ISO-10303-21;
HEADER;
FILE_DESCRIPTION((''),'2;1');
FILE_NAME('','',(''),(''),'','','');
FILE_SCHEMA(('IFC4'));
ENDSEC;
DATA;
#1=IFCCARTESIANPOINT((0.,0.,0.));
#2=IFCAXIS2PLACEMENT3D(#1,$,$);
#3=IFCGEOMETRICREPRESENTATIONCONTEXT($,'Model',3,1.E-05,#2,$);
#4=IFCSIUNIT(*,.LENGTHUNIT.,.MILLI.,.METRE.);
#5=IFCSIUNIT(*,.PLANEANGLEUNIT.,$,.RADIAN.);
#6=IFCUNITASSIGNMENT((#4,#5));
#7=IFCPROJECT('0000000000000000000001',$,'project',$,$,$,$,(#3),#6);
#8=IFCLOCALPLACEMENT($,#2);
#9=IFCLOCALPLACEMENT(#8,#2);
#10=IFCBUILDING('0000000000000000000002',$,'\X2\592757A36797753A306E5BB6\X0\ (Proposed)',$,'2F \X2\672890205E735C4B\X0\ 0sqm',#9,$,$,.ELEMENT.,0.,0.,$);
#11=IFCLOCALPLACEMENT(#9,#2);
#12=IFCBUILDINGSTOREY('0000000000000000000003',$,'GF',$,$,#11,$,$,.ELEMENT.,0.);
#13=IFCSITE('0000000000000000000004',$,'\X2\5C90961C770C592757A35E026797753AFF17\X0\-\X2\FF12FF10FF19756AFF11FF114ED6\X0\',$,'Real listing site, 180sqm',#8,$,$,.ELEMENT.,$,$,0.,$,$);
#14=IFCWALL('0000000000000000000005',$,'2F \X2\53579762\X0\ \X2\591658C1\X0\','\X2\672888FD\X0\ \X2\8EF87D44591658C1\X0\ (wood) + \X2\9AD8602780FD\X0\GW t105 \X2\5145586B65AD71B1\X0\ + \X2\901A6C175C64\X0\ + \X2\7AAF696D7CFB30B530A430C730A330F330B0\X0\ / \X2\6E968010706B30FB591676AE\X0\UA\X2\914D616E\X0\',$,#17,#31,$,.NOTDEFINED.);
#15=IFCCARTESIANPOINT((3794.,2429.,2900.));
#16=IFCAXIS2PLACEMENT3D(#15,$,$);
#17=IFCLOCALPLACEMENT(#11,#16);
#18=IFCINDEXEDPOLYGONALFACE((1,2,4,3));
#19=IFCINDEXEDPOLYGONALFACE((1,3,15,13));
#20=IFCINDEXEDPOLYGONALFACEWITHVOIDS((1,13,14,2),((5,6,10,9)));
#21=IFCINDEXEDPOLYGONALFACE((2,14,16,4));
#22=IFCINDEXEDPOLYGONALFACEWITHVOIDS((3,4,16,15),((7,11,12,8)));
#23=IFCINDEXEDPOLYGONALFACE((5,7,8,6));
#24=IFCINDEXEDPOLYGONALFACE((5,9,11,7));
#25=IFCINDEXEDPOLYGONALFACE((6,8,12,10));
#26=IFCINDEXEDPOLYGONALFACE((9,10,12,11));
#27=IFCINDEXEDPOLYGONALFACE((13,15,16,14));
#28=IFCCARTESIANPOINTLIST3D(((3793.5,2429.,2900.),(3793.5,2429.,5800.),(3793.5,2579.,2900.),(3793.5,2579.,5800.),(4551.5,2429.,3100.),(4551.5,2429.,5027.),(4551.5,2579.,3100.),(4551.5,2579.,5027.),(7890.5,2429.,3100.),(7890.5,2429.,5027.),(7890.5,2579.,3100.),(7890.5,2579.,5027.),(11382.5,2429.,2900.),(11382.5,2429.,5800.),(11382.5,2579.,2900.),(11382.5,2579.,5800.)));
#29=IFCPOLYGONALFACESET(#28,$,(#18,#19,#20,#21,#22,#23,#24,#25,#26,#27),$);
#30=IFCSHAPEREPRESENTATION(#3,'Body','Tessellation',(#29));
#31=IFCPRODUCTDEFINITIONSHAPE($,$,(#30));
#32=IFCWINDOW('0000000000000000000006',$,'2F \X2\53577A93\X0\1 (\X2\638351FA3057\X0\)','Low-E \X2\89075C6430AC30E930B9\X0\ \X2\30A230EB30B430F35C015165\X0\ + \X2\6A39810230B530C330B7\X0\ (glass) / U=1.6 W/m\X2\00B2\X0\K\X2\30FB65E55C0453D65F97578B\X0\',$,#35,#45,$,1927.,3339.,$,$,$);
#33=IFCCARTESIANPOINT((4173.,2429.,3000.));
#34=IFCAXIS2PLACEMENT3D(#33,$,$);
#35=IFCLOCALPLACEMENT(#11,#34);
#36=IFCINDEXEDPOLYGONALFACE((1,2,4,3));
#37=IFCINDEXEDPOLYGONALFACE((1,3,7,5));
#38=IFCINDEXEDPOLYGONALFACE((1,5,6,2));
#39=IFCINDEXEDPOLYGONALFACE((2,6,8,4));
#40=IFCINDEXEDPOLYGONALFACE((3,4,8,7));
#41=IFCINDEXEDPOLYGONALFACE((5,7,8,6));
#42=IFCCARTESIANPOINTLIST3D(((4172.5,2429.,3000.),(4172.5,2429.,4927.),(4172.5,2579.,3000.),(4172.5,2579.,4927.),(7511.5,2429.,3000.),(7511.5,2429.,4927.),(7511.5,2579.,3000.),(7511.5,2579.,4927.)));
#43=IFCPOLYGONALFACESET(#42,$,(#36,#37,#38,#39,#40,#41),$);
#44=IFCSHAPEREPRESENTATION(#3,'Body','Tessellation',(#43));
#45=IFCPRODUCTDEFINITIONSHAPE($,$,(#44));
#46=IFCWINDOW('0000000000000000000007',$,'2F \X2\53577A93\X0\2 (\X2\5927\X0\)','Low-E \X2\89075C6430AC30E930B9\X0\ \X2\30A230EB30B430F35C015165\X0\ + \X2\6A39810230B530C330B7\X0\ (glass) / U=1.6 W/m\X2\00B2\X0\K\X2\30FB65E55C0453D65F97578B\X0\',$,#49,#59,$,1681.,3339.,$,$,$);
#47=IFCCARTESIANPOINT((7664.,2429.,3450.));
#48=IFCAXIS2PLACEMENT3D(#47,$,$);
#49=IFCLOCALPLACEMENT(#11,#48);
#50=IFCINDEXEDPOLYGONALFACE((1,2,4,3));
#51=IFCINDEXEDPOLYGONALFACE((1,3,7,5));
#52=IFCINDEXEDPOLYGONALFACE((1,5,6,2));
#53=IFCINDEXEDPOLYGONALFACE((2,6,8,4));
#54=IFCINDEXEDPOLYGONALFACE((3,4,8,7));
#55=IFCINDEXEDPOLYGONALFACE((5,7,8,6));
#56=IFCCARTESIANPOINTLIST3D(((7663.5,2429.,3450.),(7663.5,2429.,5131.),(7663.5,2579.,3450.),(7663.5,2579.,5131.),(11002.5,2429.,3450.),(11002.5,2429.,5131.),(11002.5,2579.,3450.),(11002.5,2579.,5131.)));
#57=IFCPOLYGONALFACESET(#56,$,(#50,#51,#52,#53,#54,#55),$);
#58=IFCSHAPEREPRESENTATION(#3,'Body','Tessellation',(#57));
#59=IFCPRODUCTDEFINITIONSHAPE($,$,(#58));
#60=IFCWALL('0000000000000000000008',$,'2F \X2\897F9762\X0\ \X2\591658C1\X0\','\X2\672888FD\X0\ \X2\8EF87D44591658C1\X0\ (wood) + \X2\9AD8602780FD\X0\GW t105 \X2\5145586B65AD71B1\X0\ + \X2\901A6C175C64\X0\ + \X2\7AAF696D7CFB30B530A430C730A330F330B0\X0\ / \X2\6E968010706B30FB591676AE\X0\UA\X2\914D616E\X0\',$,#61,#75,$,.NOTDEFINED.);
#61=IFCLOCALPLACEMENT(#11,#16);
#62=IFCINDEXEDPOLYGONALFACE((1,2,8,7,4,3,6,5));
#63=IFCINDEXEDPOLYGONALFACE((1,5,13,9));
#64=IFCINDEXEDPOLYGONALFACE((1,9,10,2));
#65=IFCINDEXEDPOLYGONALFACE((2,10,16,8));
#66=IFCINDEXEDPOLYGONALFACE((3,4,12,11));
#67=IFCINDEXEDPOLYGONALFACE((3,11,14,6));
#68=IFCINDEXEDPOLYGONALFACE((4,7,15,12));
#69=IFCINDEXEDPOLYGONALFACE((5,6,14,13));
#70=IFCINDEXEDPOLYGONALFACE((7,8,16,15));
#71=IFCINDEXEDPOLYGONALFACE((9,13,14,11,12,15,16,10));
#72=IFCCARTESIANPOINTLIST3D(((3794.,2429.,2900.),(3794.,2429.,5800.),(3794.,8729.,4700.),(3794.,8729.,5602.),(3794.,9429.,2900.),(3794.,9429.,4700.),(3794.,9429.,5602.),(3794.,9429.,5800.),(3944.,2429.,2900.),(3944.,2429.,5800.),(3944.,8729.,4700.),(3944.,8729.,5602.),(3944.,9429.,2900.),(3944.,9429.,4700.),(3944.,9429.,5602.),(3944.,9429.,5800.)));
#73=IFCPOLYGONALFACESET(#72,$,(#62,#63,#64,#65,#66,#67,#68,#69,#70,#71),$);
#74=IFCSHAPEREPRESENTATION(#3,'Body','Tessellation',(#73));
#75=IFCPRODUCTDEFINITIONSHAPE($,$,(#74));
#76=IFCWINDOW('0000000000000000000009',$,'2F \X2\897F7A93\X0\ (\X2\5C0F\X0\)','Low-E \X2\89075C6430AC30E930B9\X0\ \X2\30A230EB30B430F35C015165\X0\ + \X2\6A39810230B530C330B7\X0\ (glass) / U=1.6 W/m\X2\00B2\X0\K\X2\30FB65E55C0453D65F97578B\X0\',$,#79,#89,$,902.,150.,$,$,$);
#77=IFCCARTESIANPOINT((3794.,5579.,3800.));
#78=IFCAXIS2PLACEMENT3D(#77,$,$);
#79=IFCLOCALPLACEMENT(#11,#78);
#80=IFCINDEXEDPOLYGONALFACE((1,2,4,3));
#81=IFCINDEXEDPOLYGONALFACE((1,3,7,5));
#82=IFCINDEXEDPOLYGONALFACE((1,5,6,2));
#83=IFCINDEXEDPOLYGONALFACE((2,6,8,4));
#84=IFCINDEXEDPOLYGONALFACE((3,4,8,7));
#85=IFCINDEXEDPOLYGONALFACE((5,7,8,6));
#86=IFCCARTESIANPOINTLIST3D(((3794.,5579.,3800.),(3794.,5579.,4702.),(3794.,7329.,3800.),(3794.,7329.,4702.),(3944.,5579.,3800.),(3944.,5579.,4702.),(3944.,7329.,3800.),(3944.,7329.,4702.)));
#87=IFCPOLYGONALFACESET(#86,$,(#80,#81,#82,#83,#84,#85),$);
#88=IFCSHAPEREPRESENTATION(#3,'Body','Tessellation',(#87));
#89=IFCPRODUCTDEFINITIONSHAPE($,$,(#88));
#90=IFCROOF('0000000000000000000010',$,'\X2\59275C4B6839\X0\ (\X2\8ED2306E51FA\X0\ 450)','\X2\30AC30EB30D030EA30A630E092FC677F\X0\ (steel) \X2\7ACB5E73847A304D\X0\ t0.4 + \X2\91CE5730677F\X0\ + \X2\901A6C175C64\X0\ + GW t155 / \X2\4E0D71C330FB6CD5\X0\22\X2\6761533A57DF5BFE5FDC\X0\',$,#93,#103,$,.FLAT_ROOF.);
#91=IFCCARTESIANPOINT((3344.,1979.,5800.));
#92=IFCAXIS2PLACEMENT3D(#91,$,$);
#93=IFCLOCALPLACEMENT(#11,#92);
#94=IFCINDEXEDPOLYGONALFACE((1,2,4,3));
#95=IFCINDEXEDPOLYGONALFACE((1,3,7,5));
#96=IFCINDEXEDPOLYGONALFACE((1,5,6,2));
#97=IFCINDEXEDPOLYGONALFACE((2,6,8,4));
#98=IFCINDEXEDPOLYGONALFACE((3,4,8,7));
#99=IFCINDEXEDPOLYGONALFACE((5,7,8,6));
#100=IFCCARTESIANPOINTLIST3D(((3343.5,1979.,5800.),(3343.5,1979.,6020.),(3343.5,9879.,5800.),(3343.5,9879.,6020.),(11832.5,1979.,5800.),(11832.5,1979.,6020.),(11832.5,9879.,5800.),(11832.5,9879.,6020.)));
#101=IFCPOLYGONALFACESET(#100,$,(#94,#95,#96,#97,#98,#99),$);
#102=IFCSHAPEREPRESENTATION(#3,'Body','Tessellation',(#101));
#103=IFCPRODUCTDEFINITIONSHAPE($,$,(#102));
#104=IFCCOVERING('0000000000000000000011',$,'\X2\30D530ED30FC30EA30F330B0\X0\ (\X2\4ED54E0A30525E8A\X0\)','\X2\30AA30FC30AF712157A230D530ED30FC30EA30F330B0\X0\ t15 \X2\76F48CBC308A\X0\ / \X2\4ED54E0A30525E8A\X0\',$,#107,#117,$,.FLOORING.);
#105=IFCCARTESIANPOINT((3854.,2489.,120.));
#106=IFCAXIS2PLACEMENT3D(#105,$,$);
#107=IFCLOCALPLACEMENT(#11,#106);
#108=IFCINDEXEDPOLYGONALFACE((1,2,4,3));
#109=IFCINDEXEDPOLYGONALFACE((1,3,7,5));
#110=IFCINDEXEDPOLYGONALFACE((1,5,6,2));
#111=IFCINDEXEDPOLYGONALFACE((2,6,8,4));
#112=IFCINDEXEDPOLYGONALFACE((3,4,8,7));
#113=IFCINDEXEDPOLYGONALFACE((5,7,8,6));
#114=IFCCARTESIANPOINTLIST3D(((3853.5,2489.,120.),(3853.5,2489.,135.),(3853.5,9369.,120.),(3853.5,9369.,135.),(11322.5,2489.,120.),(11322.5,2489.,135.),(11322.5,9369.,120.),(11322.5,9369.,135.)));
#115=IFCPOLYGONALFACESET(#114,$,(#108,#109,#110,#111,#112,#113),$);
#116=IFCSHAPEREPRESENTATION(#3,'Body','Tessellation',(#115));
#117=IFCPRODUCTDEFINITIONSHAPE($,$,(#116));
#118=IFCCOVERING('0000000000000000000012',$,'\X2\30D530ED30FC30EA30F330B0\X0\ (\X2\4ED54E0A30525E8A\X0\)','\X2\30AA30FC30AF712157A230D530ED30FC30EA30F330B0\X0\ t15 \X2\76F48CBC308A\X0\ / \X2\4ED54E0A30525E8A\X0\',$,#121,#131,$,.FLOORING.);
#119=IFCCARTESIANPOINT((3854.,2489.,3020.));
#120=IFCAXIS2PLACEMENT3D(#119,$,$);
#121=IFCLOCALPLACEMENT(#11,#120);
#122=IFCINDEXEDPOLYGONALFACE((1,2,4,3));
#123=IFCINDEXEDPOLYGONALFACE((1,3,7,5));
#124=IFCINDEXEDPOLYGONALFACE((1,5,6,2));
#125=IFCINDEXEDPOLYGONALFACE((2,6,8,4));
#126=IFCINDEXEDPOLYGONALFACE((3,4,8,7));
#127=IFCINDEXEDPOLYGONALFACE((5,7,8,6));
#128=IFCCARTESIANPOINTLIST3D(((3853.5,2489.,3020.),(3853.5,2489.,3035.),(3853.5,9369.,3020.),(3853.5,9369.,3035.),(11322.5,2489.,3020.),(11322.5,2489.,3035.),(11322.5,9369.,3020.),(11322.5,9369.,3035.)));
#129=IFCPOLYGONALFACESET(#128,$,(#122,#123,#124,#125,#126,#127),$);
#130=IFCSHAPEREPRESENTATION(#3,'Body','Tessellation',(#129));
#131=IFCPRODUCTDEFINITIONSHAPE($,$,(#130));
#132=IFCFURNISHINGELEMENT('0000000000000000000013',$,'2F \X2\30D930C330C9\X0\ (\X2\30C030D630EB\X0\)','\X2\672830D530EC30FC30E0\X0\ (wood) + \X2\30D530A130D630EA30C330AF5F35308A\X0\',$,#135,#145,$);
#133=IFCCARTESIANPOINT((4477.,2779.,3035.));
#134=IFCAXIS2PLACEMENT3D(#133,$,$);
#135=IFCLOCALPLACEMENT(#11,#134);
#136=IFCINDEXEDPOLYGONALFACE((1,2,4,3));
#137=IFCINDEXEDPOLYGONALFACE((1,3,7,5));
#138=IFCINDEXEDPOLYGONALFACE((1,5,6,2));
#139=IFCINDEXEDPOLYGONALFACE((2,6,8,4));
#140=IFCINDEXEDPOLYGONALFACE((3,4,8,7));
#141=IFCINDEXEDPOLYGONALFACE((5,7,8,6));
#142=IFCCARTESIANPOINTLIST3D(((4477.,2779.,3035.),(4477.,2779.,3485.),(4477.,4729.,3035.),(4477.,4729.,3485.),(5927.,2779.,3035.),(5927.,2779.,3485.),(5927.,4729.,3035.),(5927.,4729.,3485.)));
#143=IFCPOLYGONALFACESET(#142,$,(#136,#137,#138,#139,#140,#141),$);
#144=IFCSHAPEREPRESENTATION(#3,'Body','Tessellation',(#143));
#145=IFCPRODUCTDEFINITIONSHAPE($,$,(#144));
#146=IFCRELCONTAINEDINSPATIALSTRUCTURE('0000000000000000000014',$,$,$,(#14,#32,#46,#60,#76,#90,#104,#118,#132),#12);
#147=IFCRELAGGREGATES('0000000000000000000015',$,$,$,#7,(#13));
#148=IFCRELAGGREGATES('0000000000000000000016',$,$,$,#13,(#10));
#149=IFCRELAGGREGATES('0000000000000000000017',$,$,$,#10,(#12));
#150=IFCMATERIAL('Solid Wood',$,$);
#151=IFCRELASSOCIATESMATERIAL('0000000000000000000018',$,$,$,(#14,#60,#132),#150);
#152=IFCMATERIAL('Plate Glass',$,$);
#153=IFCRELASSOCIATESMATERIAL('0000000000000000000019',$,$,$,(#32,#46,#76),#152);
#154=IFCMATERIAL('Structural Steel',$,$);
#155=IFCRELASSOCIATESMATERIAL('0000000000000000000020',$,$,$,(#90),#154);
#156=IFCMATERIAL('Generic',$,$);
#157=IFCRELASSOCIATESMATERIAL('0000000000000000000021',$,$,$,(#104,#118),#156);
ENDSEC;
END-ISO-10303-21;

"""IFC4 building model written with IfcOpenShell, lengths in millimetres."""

from ifc_helpers import new_model, si_unit, frame, frame_2d, origin, place, context, project, spatial, rectangle, extrude, material, element, fill, save


model = new_model("IFC4")

# Units and contexts
model_context = context("Model", 3, precision=1e-05, world=origin())
ifc_project = project(units=[si_unit("LENGTHUNIT", "METRE", prefix="MILLI"), si_unit("PLANEANGLEUNIT", "RADIAN")], contexts=[model_context])

# Site, building, storey
site_placement = place(None, origin())
site = spatial("IfcSite", under=ifc_project, at=site_placement, Name="岐阜県大垣市林町７-２０９番１１他", ObjectType="Real listing site, 180sqm", CompositionType="ELEMENT", RefElevation=0.0)
building_placement = place(site_placement, origin())
building = spatial("IfcBuilding", under=site, at=building_placement, Name="大垣林町の家 (Proposed)", ObjectType="2F 木造平屋 0sqm", CompositionType="ELEMENT", ElevationOfRefHeight=0.0, ElevationOfTerrain=0.0)
storey_placement = place(building_placement, origin())
storey = spatial("IfcBuildingStorey", under=building, at=storey_placement, Name="GF", CompositionType="ELEMENT", Elevation=0.0)

# Shared definitions
ifc_material_1 = material(Name="Solid Wood")

# Shared definitions
ifc_material_2 = material(Name="Plate Glass")

# Wall, openings, windows
wall_1_placement = place(storey_placement, frame((3794.0, 2429.0, 2900.0)))
wall_1 = element("IfcWall", 1, at=wall_1_placement, inside=storey, material=ifc_material_1, Name="2F 南面 外壁", Description="木製 軸組外壁 (wood) + 高性能GW t105 充填断熱 + 通気層 + 窯業系サイディング / 準耐火・外皮UA配慮", PredefinedType="NOTDEFINED", context=model_context, shape_type="SweptSolid", body=[
    extrude(rectangle(XDim=7589.0, YDim=150.0, at=frame_2d((3794.0, 75.0))), frame((3794.0, 2429.0, 2900.0)), (0.0, 0.0, 1.0), 2900.0),
])
opening_1_placement = place(storey_placement, frame((4173.0, 2429.0, 3000.0)))
opening_1 = element("IfcOpeningElement", 2, at=opening_1_placement, cuts=wall_1, PredefinedType="NOTDEFINED", context=model_context, shape_type="SweptSolid", body=[
    extrude(rectangle(XDim=3339.0, YDim=150.0, at=frame_2d((1669.0, 75.0))), frame((4173.0, 2429.0, 3000.0)), (0.0, 0.0, 1.0), 1927.0),
])
opening_2_placement = place(storey_placement, frame((7664.0, 2429.0, 3450.0)))
opening_2 = element("IfcOpeningElement", 3, at=opening_2_placement, cuts=wall_1, PredefinedType="NOTDEFINED", context=model_context, shape_type="SweptSolid", body=[
    extrude(rectangle(XDim=3339.0, YDim=150.0, at=frame_2d((1669.0, 75.0))), frame((7664.0, 2429.0, 3450.0)), (0.0, 0.0, 1.0), 1681.0),
])
window_1_placement = place(storey_placement, frame((4173.0, 2429.0, 3000.0)))
window_1 = element("IfcWindow", 4, at=window_1_placement, inside=storey, material=ifc_material_2, Name="2F 南窓1 (掃出し)", Description="Low-E 複層ガラス アルゴン封入 + 樹脂サッシ (glass) / U=1.6 W/m²K・日射取得型", OverallHeight=1927.0, OverallWidth=3339.0, context=model_context, shape_type="SweptSolid", body=[
    extrude(rectangle(XDim=3339.0, YDim=150.0, at=frame_2d((1669.0, 75.0))), frame((4173.0, 2429.0, 3000.0)), (0.0, 0.0, 1.0), 1927.0),
])
fill(opening_1, window_1)
window_2_placement = place(storey_placement, frame((7664.0, 2429.0, 3450.0)))
window_2 = element("IfcWindow", 5, at=window_2_placement, inside=storey, material=ifc_material_2, Name="2F 南窓2 (大)", Description="Low-E 複層ガラス アルゴン封入 + 樹脂サッシ (glass) / U=1.6 W/m²K・日射取得型", OverallHeight=1681.0, OverallWidth=3339.0, context=model_context, shape_type="SweptSolid", body=[
    extrude(rectangle(XDim=3339.0, YDim=150.0, at=frame_2d((1669.0, 75.0))), frame((7664.0, 2429.0, 3450.0)), (0.0, 0.0, 1.0), 1681.0),
])
fill(opening_2, window_2)

# Wall, opening, window
wall_2_placement = place(storey_placement, frame((3794.0, 2429.0, 2900.0)))
wall_2 = element("IfcWall", 6, at=wall_2_placement, inside=storey, material=ifc_material_1, Name="2F 西面 外壁", Description="木製 軸組外壁 (wood) + 高性能GW t105 充填断熱 + 通気層 + 窯業系サイディング / 準耐火・外皮UA配慮", PredefinedType="NOTDEFINED", context=model_context, shape_type="SweptSolid", body=[
    extrude(rectangle(XDim=150.0, YDim=7000.0, at=frame_2d((75.0, 3500.0))), frame((3794.0, 2429.0, 2900.0)), (0.0, 0.0, 1.0), 2900.0),
])
opening_3_placement = place(storey_placement, frame((3794.0, 5579.0, 3800.0)))
opening_3 = element("IfcOpeningElement", 7, at=opening_3_placement, cuts=wall_2, PredefinedType="NOTDEFINED", context=model_context, shape_type="SweptSolid", body=[
    extrude(rectangle(XDim=150.0, YDim=1750.0, at=frame_2d((75.0, 875.0))), frame((3794.0, 5579.0, 3800.0)), (0.0, 0.0, 1.0), 902.0),
])
window_3_placement = place(storey_placement, frame((3794.0, 5579.0, 3800.0)))
window_3 = element("IfcWindow", 8, at=window_3_placement, inside=storey, material=ifc_material_2, Name="2F 西窓 (小)", Description="Low-E 複層ガラス アルゴン封入 + 樹脂サッシ (glass) / U=1.6 W/m²K・日射取得型", OverallHeight=902.0, OverallWidth=150.0, context=model_context, shape_type="SweptSolid", body=[
    extrude(rectangle(XDim=150.0, YDim=1750.0, at=frame_2d((75.0, 875.0))), frame((3794.0, 5579.0, 3800.0)), (0.0, 0.0, 1.0), 902.0),
])
fill(opening_3, window_3)

# Roof
ifc_material_3 = material(Name="Structural Steel")
roof_placement = place(storey_placement, frame((3344.0, 1979.0, 5800.0)))
element("IfcRoof", 9, at=roof_placement, inside=storey, material=ifc_material_3, Name="大屋根 (軒の出 450)", Description="ガルバリウム鋼板 (steel) 立平葺き t0.4 + 野地板 + 通気層 + GW t155 / 不燃・法22条区域対応", PredefinedType="FLAT_ROOF", context=model_context, shape_type="SweptSolid", body=[
    extrude(rectangle(XDim=8489.0, YDim=7900.0, at=frame_2d((4244.0, 3950.0))), frame((3344.0, 1979.0, 5800.0)), (0.0, 0.0, 1.0), 220.0),
])

# Coverings
ifc_material_4 = material(Name="Generic")
covering_1_placement = place(storey_placement, frame((3854.0, 2489.0, 120.0)))
element("IfcCovering", 10, at=covering_1_placement, inside=storey, material=ifc_material_4, Name="フローリング (仕上げ床)", Description="オーク無垢フローリング t15 直貼り / 仕上げ床", PredefinedType="FLOORING", context=model_context, shape_type="SweptSolid", body=[
    extrude(rectangle(XDim=7469.0, YDim=6880.0, at=frame_2d((3734.0, 3440.0))), frame((3854.0, 2489.0, 120.0)), (0.0, 0.0, 1.0), 15.0),
])
covering_2_placement = place(storey_placement, frame((3854.0, 2489.0, 3020.0)))
element("IfcCovering", 11, at=covering_2_placement, inside=storey, material=ifc_material_4, Name="フローリング (仕上げ床)", Description="オーク無垢フローリング t15 直貼り / 仕上げ床", PredefinedType="FLOORING", context=model_context, shape_type="SweptSolid", body=[
    extrude(rectangle(XDim=7469.0, YDim=6880.0, at=frame_2d((3734.0, 3440.0))), frame((3854.0, 2489.0, 3020.0)), (0.0, 0.0, 1.0), 15.0),
])

# Furnishing element
furnishing_placement = place(storey_placement, frame((4477.0, 2779.0, 3035.0)))
element("IfcFurnishingElement", 12, at=furnishing_placement, inside=storey, material=ifc_material_1, Name="2F ベッド (ダブル)", Description="木フレーム (wood) + ファブリック張り", context=model_context, shape_type="SweptSolid", body=[
    extrude(rectangle(XDim=1450.0, YDim=1950.0, at=frame_2d((725.0, 975.0))), frame((4477.0, 2779.0, 3035.0)), (0.0, 0.0, 1.0), 450.0),
])

save(model, "model.ifc")
